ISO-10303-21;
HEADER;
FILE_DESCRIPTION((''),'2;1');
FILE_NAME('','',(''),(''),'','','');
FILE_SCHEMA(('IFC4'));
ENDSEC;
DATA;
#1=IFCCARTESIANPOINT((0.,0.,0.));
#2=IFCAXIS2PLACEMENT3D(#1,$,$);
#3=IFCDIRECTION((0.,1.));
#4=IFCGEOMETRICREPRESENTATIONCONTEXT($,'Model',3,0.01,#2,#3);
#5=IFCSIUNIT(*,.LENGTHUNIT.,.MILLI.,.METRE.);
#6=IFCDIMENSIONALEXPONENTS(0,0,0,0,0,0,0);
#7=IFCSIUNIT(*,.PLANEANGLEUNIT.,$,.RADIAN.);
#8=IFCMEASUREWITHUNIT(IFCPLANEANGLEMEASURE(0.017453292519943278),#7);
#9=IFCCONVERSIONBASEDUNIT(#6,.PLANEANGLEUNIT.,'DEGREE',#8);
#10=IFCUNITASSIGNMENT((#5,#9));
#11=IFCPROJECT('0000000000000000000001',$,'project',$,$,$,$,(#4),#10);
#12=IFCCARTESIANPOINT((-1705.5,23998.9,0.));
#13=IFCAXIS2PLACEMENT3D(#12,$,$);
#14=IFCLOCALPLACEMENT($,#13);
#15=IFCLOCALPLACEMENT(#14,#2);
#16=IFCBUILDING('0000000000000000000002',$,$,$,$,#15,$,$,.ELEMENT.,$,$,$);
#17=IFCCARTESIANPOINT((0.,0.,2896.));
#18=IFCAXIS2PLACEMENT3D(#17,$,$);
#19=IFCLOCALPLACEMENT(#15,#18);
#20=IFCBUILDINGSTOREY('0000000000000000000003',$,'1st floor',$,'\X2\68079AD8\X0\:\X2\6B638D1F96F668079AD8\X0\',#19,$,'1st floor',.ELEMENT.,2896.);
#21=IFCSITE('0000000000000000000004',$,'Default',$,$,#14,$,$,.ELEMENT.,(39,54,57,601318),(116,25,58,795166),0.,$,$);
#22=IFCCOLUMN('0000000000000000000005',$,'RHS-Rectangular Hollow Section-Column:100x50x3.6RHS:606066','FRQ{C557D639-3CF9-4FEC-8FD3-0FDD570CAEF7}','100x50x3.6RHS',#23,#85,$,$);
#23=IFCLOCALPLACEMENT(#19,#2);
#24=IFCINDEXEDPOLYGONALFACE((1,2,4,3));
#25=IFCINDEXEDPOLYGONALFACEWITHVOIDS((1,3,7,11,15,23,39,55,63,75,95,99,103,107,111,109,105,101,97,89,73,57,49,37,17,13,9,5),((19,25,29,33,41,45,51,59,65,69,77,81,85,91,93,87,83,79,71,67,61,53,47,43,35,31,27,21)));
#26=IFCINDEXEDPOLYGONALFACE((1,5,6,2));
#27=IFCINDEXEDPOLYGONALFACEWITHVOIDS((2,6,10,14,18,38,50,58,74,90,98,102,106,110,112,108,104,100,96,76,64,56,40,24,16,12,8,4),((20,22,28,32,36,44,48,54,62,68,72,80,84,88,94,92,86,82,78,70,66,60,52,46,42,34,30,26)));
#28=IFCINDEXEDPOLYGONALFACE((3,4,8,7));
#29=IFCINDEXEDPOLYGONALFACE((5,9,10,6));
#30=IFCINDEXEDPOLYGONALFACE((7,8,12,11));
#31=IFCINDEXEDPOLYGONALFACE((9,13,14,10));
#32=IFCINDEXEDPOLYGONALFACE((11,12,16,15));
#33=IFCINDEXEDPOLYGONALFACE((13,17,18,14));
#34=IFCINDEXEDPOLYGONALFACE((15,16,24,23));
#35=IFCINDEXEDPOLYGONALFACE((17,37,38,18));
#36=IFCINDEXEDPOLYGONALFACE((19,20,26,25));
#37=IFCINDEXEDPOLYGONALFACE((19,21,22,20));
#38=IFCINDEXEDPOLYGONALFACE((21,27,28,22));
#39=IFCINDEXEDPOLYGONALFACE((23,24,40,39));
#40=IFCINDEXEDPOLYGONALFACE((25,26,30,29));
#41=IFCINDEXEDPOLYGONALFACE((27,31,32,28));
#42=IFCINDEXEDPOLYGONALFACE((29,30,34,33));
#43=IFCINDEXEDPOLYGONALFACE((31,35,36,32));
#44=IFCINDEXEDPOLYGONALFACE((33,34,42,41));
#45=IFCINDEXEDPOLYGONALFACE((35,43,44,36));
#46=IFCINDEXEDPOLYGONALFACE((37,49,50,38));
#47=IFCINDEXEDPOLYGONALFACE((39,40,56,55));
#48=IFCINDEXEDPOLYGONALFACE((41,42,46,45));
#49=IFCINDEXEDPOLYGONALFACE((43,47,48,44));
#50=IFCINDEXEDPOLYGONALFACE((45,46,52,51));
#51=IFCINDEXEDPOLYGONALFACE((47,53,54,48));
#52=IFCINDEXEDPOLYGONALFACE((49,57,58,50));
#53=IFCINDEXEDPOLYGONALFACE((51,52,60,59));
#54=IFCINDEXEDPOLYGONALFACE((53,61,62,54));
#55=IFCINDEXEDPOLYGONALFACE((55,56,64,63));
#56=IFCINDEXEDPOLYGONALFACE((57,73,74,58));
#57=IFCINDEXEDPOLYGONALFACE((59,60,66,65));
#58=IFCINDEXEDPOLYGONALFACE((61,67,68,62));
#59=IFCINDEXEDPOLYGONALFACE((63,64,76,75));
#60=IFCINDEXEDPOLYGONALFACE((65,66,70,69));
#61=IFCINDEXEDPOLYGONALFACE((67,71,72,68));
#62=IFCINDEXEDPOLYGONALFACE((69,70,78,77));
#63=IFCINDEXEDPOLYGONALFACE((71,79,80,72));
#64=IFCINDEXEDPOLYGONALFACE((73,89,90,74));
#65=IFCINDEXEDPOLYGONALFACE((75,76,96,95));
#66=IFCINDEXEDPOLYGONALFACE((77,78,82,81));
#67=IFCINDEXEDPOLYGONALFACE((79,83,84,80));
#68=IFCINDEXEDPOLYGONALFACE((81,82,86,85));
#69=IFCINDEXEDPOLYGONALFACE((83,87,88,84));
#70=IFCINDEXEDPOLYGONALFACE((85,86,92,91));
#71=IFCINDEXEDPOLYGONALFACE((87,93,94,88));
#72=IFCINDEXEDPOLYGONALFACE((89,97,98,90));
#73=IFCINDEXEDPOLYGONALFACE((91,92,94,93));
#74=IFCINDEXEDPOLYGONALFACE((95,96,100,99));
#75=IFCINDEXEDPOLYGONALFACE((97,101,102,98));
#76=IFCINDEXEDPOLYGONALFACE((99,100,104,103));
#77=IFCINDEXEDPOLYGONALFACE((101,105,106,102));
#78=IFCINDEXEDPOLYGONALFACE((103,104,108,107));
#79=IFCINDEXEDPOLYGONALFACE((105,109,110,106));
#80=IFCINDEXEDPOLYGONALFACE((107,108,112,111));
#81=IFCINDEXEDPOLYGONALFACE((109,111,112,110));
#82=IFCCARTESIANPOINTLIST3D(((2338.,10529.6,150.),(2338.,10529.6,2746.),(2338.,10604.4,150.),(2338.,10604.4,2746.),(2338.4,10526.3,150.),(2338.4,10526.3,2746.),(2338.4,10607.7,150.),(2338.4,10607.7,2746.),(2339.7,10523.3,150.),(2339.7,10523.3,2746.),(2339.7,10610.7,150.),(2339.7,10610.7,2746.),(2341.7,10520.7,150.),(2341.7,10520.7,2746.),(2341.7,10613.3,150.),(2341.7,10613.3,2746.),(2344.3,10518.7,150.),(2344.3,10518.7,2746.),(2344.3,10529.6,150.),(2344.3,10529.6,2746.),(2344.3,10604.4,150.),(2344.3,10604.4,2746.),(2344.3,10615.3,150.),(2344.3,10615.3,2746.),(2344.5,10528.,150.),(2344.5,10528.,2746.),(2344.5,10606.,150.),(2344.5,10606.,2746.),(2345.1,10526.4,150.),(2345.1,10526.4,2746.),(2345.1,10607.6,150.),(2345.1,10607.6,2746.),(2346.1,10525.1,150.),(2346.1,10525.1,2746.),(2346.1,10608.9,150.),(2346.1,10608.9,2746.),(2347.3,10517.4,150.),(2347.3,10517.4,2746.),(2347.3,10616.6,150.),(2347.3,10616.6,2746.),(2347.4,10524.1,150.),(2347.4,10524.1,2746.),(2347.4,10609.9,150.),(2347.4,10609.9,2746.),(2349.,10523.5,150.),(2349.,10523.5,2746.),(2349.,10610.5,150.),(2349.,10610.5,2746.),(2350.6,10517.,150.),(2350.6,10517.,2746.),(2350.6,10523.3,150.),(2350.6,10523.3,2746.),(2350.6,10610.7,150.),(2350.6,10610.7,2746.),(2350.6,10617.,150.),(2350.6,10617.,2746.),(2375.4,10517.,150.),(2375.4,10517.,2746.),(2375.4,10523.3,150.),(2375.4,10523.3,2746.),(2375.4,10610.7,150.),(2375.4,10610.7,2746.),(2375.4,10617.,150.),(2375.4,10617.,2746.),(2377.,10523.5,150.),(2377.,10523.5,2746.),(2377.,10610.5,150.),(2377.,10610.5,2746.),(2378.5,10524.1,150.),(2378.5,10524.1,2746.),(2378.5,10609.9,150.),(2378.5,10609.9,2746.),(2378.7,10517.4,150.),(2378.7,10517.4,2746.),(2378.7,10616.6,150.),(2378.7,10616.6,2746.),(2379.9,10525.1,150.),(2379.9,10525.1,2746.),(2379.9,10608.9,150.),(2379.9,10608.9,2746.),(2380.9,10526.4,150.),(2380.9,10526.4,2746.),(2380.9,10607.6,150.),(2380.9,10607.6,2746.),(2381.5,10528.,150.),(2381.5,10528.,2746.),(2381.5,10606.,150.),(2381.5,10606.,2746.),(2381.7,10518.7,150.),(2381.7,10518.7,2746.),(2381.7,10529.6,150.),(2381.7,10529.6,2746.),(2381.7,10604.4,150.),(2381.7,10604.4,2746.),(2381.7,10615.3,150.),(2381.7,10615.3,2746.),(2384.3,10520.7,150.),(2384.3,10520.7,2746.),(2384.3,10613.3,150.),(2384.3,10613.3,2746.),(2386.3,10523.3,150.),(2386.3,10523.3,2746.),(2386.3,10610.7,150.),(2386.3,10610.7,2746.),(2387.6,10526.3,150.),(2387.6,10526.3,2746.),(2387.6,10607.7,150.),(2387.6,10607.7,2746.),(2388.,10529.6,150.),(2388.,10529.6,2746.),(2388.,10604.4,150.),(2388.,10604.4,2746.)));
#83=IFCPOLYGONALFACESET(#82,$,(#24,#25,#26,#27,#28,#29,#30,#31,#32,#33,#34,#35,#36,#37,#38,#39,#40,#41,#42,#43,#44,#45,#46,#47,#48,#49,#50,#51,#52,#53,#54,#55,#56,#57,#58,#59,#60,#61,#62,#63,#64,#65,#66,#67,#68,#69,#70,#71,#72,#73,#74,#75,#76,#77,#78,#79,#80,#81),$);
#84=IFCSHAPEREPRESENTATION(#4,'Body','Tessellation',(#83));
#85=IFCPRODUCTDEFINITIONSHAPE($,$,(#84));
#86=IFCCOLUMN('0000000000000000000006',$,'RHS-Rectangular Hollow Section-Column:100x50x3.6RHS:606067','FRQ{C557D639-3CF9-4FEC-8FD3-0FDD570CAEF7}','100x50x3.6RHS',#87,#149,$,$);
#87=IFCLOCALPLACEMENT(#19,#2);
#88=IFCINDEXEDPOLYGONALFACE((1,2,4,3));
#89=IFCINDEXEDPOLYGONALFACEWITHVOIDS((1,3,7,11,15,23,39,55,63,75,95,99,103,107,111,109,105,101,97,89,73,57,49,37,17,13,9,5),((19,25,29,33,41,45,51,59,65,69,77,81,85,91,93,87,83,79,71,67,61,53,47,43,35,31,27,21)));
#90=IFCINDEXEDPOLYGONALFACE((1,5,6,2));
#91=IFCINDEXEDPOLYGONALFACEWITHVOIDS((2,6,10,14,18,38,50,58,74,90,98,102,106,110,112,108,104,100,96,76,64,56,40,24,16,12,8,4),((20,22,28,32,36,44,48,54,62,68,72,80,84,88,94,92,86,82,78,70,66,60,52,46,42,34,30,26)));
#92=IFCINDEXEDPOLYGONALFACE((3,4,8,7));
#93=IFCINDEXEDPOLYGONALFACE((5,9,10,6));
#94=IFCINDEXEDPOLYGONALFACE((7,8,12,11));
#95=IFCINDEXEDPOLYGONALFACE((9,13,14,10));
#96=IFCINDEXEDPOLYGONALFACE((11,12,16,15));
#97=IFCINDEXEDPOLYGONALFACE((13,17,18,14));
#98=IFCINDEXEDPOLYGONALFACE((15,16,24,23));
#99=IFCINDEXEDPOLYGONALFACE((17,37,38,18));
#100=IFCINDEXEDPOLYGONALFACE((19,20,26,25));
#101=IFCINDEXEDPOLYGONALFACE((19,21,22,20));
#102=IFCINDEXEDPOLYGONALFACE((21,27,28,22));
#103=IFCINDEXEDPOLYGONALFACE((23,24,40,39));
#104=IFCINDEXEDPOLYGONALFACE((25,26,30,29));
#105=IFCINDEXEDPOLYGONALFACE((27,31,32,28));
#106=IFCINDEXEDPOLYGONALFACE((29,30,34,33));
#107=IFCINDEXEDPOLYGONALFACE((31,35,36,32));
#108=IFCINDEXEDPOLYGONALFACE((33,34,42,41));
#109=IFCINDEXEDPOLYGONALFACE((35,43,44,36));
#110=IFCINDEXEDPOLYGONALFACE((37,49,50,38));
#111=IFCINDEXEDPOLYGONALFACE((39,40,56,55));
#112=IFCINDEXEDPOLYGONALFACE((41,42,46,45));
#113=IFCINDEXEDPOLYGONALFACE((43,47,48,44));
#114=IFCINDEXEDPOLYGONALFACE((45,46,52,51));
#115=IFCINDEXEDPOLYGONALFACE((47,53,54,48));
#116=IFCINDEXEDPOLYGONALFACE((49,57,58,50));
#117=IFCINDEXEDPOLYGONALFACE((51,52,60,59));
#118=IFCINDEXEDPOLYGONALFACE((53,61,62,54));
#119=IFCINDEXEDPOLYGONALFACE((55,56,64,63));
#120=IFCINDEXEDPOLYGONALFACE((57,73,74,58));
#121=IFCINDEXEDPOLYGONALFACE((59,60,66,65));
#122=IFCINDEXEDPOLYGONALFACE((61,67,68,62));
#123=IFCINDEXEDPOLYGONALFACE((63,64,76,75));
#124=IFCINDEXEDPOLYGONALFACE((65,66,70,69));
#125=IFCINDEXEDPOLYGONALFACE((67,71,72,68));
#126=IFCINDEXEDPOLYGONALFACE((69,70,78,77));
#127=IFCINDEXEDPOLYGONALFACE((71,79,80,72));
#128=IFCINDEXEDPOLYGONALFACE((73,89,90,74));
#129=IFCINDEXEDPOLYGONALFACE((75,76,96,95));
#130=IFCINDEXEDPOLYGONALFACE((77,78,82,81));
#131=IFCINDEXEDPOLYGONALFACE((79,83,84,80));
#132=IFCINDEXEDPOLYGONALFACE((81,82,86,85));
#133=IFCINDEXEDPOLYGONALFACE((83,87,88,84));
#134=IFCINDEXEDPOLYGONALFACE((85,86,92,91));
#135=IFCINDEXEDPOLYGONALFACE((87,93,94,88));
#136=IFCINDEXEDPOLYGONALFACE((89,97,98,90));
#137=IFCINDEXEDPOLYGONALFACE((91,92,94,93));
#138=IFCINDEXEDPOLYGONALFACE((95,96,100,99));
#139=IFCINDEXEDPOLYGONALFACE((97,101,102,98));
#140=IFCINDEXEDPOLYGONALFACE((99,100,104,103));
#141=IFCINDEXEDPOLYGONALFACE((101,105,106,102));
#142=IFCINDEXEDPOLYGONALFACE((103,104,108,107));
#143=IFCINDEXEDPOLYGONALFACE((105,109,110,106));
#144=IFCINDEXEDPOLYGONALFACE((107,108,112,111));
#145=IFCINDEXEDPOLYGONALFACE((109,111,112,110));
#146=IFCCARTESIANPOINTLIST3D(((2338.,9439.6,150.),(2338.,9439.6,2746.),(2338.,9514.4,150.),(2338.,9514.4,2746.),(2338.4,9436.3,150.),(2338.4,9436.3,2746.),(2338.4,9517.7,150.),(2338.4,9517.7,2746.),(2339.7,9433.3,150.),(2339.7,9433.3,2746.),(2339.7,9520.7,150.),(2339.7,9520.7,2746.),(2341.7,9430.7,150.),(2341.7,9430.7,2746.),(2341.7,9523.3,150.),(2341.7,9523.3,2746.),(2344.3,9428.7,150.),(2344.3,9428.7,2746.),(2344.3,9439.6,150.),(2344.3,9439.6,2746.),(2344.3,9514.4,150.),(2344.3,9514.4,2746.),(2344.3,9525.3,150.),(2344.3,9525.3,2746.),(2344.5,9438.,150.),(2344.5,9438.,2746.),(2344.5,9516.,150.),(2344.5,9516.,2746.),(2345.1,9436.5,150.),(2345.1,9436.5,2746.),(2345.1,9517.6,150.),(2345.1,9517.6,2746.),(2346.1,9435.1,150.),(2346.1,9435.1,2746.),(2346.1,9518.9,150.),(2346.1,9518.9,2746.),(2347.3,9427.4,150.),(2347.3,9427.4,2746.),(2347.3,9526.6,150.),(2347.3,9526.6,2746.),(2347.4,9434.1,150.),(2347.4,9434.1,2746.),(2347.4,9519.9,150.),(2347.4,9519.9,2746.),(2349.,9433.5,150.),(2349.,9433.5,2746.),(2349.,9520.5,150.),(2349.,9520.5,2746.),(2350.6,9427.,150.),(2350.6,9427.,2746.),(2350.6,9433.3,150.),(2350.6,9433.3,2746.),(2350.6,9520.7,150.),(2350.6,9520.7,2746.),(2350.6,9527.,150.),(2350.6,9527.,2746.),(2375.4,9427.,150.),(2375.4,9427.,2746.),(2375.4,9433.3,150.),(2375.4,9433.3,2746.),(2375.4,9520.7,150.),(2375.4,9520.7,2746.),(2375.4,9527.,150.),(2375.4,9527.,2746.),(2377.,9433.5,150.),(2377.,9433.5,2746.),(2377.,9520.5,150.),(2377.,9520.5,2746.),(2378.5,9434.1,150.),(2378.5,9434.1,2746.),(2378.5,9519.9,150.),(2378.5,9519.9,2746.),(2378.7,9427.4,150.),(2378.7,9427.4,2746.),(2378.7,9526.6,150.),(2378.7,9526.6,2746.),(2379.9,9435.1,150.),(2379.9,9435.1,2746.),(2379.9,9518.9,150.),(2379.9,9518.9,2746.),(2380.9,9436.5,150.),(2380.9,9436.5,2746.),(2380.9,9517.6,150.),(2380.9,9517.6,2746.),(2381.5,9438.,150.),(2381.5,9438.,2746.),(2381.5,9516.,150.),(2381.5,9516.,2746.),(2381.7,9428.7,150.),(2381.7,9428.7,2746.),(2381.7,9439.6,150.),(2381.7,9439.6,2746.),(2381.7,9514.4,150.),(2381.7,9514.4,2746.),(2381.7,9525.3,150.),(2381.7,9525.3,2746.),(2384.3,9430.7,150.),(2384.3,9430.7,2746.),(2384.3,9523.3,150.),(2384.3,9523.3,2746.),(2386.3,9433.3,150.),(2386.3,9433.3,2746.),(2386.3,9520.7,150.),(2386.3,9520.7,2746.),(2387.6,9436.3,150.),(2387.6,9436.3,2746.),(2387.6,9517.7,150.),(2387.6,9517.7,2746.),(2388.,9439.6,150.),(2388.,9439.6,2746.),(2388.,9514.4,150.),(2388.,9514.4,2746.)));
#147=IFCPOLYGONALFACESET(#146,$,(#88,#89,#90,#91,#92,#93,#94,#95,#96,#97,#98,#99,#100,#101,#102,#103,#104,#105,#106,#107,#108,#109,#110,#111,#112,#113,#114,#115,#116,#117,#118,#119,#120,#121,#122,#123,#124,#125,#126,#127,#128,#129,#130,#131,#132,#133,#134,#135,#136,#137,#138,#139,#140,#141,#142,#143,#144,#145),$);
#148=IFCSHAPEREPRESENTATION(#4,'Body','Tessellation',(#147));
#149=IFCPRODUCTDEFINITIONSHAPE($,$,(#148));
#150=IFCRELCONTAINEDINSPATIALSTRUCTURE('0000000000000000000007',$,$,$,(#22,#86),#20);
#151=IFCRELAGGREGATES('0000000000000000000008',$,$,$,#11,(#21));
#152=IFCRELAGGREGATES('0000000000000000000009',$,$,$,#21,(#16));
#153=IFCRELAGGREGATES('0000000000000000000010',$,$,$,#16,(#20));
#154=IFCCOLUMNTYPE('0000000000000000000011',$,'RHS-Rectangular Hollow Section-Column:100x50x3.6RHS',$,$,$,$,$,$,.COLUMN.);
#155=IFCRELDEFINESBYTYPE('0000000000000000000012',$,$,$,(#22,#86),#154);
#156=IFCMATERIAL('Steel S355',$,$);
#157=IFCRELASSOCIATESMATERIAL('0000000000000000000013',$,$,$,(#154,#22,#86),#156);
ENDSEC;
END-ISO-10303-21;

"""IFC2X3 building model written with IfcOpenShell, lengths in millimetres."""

from ifc_helpers import new_model, entity, si_unit, converted_unit, direction, frame, origin, origin_2d, place, context, project, spatial, hollow_rectangle, extrude, clip, halfspace, material, type_object, element, save


model = new_model("IFC2X3")

# Units and contexts
model_context = context("Model", 3, precision=0.01, world=origin(), true_north=direction((0.0, 1.0)))
ifc_project = project(units=[si_unit("LENGTHUNIT", "METRE", prefix="MILLI"), converted_unit("PLANEANGLEUNIT", "DEGREE", entity("IfcPlaneAngleMeasure", 0.017453292519943278), si_unit("PLANEANGLEUNIT", "RADIAN"), dimensions=[0, 0, 0, 0, 0, 0, 0])], contexts=[model_context])

# Site, building, storey
site_placement = place(None, frame((-1705.5, 23998.9, 0.0)))
site = spatial("IfcSite", under=ifc_project, at=site_placement, Name="Default", CompositionType="ELEMENT", RefLatitude=(39, 54, 57, 601318), RefLongitude=(116, 25, 58, 795166), RefElevation=0.0)
building_placement = place(site_placement, origin())
building = spatial("IfcBuilding", under=site, at=building_placement, CompositionType="ELEMENT")
storey_placement = place(building_placement, frame((0.0, 0.0, 2896.0)))
storey = spatial("IfcBuildingStorey", under=building, at=storey_placement, Name="1st floor", ObjectType="标高:正负零标高", LongName="1st floor", CompositionType="ELEMENT", Elevation=2896.0)

# Shared definitions
ifc_material_1 = material(Name="Steel S355")

# Columns
column_type_1 = type_object("IfcColumnType", Name="RHS-Rectangular Hollow Section-Column:100x50x3.6RHS", PredefinedType="COLUMN", material=ifc_material_1)
column_1_placement = place(storey_placement, frame((2363.0, 10567.0, 2746.0), z_axis=(0.0, 0.0, 1.0), x_axis=(-1.0, 0.0, 0.0)))
element("IfcColumn", 1, at=column_1_placement, inside=storey, type_object=column_type_1, material=ifc_material_1, Name="RHS-Rectangular Hollow Section-Column:100x50x3.6RHS:606066", Description="FRQ{C557D639-3CF9-4FEC-8FD3-0FDD570CAEF7}", ObjectType="100x50x3.6RHS", context=model_context, shape_type="Clipping", body=[
    clip(extrude(hollow_rectangle(XDim=50.0, YDim=100.0, WallThickness=6.3, InnerFilletRadius=6.3, OuterFilletRadius=12.6, at=origin_2d()), origin(), (0.0, 0.0, -1.0), 2651.9), halfspace(frame((2363.0, 10567.0, -2596.0), z_axis=(0.0, 0.0, 1.0), x_axis=(-1.0, 0.0, 0.0)), True)),
])
column_2_placement = place(storey_placement, frame((2363.0, 9477.0, 2746.0), z_axis=(0.0, 0.0, 1.0), x_axis=(-1.0, 0.0, 0.0)))
element("IfcColumn", 2, at=column_2_placement, inside=storey, type_object=column_type_1, material=ifc_material_1, Name="RHS-Rectangular Hollow Section-Column:100x50x3.6RHS:606067", Description="FRQ{C557D639-3CF9-4FEC-8FD3-0FDD570CAEF7}", ObjectType="100x50x3.6RHS", context=model_context, shape_type="Clipping", body=[
    clip(extrude(hollow_rectangle(XDim=50.0, YDim=100.0, WallThickness=6.3, InnerFilletRadius=6.3, OuterFilletRadius=12.6, at=origin_2d()), origin(), (0.0, 0.0, -1.0), 2651.9), halfspace(frame((2363.0, 9477.0, -2596.0), z_axis=(0.0, 0.0, 1.0), x_axis=(-1.0, 0.0, 0.0)), True)),
])

save(model, "model.ifc")
